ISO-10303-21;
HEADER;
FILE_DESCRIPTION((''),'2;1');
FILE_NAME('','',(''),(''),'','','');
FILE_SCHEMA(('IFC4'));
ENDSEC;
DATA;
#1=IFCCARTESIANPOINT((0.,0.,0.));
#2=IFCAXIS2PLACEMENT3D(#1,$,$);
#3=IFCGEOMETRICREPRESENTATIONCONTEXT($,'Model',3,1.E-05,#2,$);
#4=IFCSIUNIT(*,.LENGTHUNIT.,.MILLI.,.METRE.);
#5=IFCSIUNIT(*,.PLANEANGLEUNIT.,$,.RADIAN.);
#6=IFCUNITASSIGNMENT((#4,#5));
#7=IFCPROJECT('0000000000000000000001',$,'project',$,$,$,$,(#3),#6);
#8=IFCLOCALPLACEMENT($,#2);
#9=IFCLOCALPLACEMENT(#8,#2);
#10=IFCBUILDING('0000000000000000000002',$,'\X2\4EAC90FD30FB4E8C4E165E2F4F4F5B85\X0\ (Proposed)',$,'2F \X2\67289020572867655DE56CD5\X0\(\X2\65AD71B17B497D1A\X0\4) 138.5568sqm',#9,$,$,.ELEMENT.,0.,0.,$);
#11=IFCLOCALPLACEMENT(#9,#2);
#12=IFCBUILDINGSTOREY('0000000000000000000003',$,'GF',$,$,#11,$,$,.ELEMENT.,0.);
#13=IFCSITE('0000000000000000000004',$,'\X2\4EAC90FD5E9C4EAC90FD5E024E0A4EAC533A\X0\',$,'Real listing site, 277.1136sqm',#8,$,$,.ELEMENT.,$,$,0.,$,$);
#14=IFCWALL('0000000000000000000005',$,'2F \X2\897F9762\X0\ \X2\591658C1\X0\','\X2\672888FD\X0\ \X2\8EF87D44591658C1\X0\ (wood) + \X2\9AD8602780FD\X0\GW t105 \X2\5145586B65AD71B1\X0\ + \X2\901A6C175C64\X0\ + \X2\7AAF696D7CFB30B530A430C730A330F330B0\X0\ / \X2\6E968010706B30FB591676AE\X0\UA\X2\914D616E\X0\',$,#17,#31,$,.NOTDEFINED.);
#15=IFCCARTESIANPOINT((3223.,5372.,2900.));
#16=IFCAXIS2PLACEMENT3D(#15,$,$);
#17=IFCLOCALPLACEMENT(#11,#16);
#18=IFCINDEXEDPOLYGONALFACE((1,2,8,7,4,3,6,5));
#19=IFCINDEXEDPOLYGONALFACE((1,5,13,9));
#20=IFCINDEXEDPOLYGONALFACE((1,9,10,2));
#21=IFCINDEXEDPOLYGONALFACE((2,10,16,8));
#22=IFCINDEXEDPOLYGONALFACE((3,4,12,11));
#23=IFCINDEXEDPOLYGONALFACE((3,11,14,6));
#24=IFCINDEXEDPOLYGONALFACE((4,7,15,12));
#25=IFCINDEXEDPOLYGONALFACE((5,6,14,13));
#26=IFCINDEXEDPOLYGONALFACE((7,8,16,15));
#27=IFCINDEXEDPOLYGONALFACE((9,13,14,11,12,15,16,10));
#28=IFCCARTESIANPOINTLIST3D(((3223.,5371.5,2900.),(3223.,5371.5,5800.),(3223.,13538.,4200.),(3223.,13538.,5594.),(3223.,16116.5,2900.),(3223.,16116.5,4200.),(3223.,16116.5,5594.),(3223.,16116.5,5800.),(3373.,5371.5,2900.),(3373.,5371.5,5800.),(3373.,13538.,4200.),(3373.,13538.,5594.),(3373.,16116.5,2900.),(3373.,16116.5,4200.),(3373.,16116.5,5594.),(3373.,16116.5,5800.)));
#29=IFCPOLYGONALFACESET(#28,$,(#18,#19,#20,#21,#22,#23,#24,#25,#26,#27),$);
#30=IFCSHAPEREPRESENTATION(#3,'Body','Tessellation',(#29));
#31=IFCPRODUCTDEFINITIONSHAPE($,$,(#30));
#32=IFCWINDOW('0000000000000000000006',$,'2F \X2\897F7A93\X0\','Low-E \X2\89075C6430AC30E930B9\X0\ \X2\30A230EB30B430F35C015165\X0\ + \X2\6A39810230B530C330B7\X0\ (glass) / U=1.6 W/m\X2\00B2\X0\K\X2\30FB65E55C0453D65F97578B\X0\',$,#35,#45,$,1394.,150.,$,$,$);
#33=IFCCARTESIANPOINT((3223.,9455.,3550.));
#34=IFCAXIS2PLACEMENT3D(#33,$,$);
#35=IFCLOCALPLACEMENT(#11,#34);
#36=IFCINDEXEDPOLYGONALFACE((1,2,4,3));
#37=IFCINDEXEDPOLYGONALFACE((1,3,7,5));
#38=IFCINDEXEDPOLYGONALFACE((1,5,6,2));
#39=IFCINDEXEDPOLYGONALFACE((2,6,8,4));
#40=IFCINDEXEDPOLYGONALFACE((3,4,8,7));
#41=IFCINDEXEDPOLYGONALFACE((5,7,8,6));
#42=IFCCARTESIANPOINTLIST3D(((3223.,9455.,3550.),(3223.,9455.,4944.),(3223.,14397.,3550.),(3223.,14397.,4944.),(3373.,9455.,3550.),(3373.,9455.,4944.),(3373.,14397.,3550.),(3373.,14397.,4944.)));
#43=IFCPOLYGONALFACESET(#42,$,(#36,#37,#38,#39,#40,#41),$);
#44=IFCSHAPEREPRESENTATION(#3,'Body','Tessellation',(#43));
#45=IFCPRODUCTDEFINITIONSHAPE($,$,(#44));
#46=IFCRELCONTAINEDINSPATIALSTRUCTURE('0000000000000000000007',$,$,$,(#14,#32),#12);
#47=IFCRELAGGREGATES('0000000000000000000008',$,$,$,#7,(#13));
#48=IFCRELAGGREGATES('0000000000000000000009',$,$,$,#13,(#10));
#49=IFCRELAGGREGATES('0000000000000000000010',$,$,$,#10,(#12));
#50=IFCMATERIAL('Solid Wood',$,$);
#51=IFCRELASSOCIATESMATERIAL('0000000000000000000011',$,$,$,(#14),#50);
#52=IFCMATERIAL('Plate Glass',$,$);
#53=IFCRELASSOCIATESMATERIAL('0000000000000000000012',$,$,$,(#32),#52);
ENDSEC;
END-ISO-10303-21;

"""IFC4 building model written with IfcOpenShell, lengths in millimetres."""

from ifc_helpers import new_model, si_unit, frame, frame_2d, origin, place, context, project, spatial, rectangle, extrude, material, element, fill, save


model = new_model("IFC4")

# Units and contexts
model_context = context("Model", 3, precision=1e-05, world=origin())
ifc_project = project(units=[si_unit("LENGTHUNIT", "METRE", prefix="MILLI"), si_unit("PLANEANGLEUNIT", "RADIAN")], contexts=[model_context])

# Site, building, storey
site_placement = place(None, origin())
site = spatial("IfcSite", under=ifc_project, at=site_placement, Name="京都府京都市上京区", ObjectType="Real listing site, 277.1136sqm", CompositionType="ELEMENT", RefElevation=0.0)
building_placement = place(site_placement, origin())
building = spatial("IfcBuilding", under=site, at=building_placement, Name="京都・二世帯住宅 (Proposed)", ObjectType="2F 木造在来工法(断熱等級4) 138.5568sqm", CompositionType="ELEMENT", ElevationOfRefHeight=0.0, ElevationOfTerrain=0.0)
storey_placement = place(building_placement, origin())
storey = spatial("IfcBuildingStorey", under=building, at=storey_placement, Name="GF", CompositionType="ELEMENT", Elevation=0.0)

# Shared definitions
ifc_material_1 = material(Name="Solid Wood")

# Shared definitions
ifc_material_2 = material(Name="Plate Glass")

# Wall, opening, window
wall_1_placement = place(storey_placement, frame((3223.0, 5372.0, 2900.0)))
wall_1 = element("IfcWall", 1, at=wall_1_placement, inside=storey, material=ifc_material_1, Name="2F 西面 外壁", Description="木製 軸組外壁 (wood) + 高性能GW t105 充填断熱 + 通気層 + 窯業系サイディング / 準耐火・外皮UA配慮", PredefinedType="NOTDEFINED", context=model_context, shape_type="SweptSolid", body=[
    extrude(rectangle(XDim=150.0, YDim=10745.0, at=frame_2d((75.0, 5372.0))), frame((3223.0, 5372.0, 2900.0)), (0.0, 0.0, 1.0), 2900.0),
])
opening_1_placement = place(storey_placement, frame((3223.0, 9455.0, 3550.0)))
opening_1 = element("IfcOpeningElement", 2, at=opening_1_placement, cuts=wall_1, PredefinedType="NOTDEFINED", context=model_context, shape_type="SweptSolid", body=[
    extrude(rectangle(XDim=150.0, YDim=4942.0, at=frame_2d((75.0, 2471.0))), frame((3223.0, 9455.0, 3550.0)), (0.0, 0.0, 1.0), 1394.0),
])
window_1_placement = place(storey_placement, frame((3223.0, 9455.0, 3550.0)))
window_1 = element("IfcWindow", 3, at=window_1_placement, inside=storey, material=ifc_material_2, Name="2F 西窓", Description="Low-E 複層ガラス アルゴン封入 + 樹脂サッシ (glass) / U=1.6 W/m²K・日射取得型", OverallHeight=1394.0, OverallWidth=150.0, context=model_context, shape_type="SweptSolid", body=[
    extrude(rectangle(XDim=150.0, YDim=4942.0, at=frame_2d((75.0, 2471.0))), frame((3223.0, 9455.0, 3550.0)), (0.0, 0.0, 1.0), 1394.0),
])
fill(opening_1, window_1)

save(model, "model.ifc")
